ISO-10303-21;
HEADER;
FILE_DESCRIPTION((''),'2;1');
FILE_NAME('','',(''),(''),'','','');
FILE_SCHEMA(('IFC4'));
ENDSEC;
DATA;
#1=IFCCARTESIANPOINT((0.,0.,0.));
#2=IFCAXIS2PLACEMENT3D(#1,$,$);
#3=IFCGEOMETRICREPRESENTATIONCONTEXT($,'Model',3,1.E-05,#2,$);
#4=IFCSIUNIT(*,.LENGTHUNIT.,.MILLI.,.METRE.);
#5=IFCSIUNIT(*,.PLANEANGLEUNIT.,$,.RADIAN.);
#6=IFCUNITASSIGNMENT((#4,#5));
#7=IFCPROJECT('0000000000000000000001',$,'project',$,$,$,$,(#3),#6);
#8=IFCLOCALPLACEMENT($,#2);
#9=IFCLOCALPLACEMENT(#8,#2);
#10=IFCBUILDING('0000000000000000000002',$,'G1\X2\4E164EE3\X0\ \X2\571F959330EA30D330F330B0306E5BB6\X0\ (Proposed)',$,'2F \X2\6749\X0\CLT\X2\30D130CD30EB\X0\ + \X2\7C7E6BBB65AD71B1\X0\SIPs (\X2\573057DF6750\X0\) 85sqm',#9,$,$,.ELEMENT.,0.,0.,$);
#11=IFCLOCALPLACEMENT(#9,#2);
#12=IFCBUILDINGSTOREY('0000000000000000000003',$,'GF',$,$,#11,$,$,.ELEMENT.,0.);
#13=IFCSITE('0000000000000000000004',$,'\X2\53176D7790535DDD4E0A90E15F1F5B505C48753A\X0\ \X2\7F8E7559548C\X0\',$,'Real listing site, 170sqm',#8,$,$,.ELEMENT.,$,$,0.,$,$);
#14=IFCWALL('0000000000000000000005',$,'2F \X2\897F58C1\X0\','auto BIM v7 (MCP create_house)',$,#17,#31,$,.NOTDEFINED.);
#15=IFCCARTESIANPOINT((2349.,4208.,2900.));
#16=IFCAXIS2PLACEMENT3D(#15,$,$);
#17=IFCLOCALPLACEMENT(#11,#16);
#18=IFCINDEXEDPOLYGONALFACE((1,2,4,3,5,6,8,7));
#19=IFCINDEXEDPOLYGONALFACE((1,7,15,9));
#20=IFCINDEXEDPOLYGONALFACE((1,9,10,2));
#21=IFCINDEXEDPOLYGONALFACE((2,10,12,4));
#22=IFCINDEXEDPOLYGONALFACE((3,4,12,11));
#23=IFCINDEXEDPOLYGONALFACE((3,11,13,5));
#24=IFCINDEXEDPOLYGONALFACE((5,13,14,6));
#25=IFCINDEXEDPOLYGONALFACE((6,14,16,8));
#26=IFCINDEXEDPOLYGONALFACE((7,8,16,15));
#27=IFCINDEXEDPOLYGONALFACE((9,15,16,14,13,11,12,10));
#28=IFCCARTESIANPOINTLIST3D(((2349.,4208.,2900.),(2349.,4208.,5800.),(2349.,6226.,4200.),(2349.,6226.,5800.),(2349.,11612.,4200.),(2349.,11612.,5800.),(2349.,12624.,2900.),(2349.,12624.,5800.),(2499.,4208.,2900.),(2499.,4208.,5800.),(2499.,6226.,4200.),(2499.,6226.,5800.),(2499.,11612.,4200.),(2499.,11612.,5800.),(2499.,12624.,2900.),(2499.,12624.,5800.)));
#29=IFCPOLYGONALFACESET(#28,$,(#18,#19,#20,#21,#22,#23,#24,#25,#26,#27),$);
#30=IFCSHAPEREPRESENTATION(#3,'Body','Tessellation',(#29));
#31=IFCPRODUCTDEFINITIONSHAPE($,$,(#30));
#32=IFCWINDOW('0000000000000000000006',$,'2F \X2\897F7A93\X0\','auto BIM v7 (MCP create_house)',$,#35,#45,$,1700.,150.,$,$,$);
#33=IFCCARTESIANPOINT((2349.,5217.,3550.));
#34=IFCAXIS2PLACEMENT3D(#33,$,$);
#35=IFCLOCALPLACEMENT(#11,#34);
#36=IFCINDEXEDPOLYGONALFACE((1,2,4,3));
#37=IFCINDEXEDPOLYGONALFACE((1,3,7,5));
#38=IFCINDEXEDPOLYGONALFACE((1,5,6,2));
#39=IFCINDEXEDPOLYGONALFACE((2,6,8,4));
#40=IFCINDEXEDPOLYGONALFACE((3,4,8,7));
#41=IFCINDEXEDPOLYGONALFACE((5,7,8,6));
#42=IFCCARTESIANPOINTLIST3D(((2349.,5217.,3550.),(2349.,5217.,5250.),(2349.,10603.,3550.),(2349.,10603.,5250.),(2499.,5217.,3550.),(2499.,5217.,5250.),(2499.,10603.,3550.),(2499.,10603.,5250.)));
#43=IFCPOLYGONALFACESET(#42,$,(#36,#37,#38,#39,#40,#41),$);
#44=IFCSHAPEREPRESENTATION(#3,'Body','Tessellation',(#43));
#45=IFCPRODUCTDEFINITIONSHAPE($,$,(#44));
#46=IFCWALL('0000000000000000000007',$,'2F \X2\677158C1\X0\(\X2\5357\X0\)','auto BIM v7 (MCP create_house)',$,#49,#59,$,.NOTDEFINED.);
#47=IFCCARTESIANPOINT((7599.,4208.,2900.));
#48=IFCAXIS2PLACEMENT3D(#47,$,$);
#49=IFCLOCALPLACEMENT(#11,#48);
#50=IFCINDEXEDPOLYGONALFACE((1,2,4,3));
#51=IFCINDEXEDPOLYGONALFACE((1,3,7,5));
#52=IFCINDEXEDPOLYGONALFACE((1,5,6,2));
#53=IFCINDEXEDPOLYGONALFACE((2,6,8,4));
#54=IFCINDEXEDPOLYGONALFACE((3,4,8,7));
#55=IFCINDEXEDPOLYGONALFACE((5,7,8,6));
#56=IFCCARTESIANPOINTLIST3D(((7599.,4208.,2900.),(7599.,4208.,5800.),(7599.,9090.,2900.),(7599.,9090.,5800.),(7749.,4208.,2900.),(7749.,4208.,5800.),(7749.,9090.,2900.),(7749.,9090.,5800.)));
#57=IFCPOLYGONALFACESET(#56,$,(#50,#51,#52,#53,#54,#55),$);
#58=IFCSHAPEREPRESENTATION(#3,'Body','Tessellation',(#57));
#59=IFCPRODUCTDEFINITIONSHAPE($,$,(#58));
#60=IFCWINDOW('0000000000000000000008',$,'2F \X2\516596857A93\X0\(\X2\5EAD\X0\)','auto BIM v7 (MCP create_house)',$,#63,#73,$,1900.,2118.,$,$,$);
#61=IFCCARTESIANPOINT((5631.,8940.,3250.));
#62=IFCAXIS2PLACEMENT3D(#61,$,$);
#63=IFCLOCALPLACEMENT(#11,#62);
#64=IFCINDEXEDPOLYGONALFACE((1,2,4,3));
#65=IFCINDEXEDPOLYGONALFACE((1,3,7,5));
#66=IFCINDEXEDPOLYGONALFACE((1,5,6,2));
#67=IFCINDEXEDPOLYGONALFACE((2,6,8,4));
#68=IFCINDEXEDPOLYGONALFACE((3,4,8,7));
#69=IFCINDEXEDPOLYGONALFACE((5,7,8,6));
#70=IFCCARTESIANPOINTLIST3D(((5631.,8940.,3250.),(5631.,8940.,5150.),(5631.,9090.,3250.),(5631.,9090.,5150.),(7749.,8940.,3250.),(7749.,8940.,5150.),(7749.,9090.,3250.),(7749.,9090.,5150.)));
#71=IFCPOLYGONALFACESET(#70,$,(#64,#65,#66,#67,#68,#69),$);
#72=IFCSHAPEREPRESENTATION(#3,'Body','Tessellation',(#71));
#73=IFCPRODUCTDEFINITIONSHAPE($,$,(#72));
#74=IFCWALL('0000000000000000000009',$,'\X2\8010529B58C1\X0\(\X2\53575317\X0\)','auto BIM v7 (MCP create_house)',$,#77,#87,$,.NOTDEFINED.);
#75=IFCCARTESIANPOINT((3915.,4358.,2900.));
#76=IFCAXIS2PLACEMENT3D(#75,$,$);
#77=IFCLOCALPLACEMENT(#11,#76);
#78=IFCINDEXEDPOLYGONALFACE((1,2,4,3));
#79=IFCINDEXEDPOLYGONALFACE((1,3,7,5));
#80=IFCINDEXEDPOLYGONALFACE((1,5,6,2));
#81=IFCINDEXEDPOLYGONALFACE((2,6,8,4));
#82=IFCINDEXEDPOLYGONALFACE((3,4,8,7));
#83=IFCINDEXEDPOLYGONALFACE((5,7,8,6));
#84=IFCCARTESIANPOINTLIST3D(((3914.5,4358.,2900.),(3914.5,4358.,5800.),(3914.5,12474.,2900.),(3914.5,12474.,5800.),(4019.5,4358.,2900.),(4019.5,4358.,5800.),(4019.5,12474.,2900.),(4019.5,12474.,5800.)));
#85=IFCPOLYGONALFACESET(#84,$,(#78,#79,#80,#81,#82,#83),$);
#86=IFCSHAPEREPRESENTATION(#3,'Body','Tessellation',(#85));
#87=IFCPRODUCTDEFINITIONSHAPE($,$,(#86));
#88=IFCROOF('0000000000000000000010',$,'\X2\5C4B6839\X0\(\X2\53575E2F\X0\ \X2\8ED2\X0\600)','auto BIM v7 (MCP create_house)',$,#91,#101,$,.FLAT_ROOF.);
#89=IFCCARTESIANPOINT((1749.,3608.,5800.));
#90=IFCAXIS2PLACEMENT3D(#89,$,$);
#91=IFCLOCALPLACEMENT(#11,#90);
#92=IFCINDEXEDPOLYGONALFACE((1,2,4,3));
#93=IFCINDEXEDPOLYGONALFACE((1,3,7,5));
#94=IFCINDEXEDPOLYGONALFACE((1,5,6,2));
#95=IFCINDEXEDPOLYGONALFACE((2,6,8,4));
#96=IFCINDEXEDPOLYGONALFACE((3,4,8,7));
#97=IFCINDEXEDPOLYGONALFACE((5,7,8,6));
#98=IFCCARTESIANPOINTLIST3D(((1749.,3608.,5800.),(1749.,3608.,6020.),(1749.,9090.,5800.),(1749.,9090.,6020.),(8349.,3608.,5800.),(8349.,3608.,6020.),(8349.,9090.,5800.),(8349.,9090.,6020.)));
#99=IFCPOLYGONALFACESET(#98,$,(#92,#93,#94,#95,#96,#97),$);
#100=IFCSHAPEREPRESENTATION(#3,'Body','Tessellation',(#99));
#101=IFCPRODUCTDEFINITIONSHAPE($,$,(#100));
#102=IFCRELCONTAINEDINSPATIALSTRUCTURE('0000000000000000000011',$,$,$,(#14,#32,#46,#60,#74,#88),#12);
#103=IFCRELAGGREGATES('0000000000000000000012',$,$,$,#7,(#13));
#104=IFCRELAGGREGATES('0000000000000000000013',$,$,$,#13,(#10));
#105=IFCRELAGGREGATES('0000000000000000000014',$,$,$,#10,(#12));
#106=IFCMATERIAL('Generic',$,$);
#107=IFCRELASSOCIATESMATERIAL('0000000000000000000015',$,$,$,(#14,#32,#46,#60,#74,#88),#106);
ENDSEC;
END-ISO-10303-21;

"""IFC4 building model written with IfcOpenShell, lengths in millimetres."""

from ifc_helpers import new_model, si_unit, frame, frame_2d, origin, place, context, project, spatial, rectangle, extrude, material, element, fill, save


model = new_model("IFC4")

# Units and contexts
model_context = context("Model", 3, precision=1e-05, world=origin())
ifc_project = project(units=[si_unit("LENGTHUNIT", "METRE", prefix="MILLI"), si_unit("PLANEANGLEUNIT", "RADIAN")], contexts=[model_context])

# Site, building, storey
site_placement = place(None, origin())
site = spatial("IfcSite", under=ifc_project, at=site_placement, Name="北海道川上郡弟子屈町 美留和", ObjectType="Real listing site, 170sqm", CompositionType="ELEMENT", RefElevation=0.0)
building_placement = place(site_placement, origin())
building = spatial("IfcBuilding", under=site, at=building_placement, Name="G1世代 土間リビングの家 (Proposed)", ObjectType="2F 杉CLTパネル + 籾殻断熱SIPs (地域材) 85sqm", CompositionType="ELEMENT", ElevationOfRefHeight=0.0, ElevationOfTerrain=0.0)
storey_placement = place(building_placement, origin())
storey = spatial("IfcBuildingStorey", under=building, at=storey_placement, Name="GF", CompositionType="ELEMENT", Elevation=0.0)

# Shared definitions
ifc_material = material(Name="Generic")

# Walls, openings, windows
wall_1_placement = place(storey_placement, frame((2349.0, 4208.0, 2900.0)))
wall_1 = element("IfcWall", 1, at=wall_1_placement, inside=storey, material=ifc_material, Name="2F 西壁", Description="auto BIM v7 (MCP create_house)", PredefinedType="NOTDEFINED", context=model_context, shape_type="SweptSolid", body=[
    extrude(rectangle(XDim=150.0, YDim=8416.0, at=frame_2d((75.0, 4208.0))), frame((2349.0, 4208.0, 2900.0)), (0.0, 0.0, 1.0), 2900.0),
])
opening_1_placement = place(storey_placement, frame((2349.0, 5217.0, 3550.0)))
opening_1 = element("IfcOpeningElement", 2, at=opening_1_placement, cuts=wall_1, PredefinedType="NOTDEFINED", context=model_context, shape_type="SweptSolid", body=[
    extrude(rectangle(XDim=150.0, YDim=5386.0, at=frame_2d((75.0, 2693.0))), frame((2349.0, 5217.0, 3550.0)), (0.0, 0.0, 1.0), 1700.0),
])
window_1_placement = place(storey_placement, frame((2349.0, 5217.0, 3550.0)))
window_1 = element("IfcWindow", 3, at=window_1_placement, inside=storey, material=ifc_material, Name="2F 西窓", Description="auto BIM v7 (MCP create_house)", OverallHeight=1700.0, OverallWidth=150.0, context=model_context, shape_type="SweptSolid", body=[
    extrude(rectangle(XDim=150.0, YDim=5386.0, at=frame_2d((75.0, 2693.0))), frame((2349.0, 5217.0, 3550.0)), (0.0, 0.0, 1.0), 1700.0),
])
fill(opening_1, window_1)
wall_2_placement = place(storey_placement, frame((7599.0, 4208.0, 2900.0)))
wall_2 = element("IfcWall", 4, at=wall_2_placement, inside=storey, material=ifc_material, Name="2F 東壁(南)", Description="auto BIM v7 (MCP create_house)", PredefinedType="NOTDEFINED", context=model_context, shape_type="SweptSolid", body=[
    extrude(rectangle(XDim=150.0, YDim=4882.0, at=frame_2d((75.0, 2441.0))), frame((7599.0, 4208.0, 2900.0)), (0.0, 0.0, 1.0), 2900.0),
])
opening_2_placement = place(storey_placement, frame((5631.0, 8940.0, 3250.0)))
opening_2 = element("IfcOpeningElement", 5, at=opening_2_placement, cuts=wall_2, PredefinedType="NOTDEFINED", context=model_context, shape_type="SweptSolid", body=[
    extrude(rectangle(XDim=2118.0, YDim=150.0, at=frame_2d((1059.0, 75.0))), frame((5631.0, 8940.0, 3250.0)), (0.0, 0.0, 1.0), 1900.0),
])
window_2_placement = place(storey_placement, frame((5631.0, 8940.0, 3250.0)))
window_2 = element("IfcWindow", 6, at=window_2_placement, inside=storey, material=ifc_material, Name="2F 入隅窓(庭)", Description="auto BIM v7 (MCP create_house)", OverallHeight=1900.0, OverallWidth=2118.0, context=model_context, shape_type="SweptSolid", body=[
    extrude(rectangle(XDim=2118.0, YDim=150.0, at=frame_2d((1059.0, 75.0))), frame((5631.0, 8940.0, 3250.0)), (0.0, 0.0, 1.0), 1900.0),
])
fill(opening_2, window_2)

# Wall
wall_3_placement = place(storey_placement, frame((3915.0, 4358.0, 2900.0)))
element("IfcWall", 7, at=wall_3_placement, inside=storey, material=ifc_material, Name="耐力壁(南北)", Description="auto BIM v7 (MCP create_house)", PredefinedType="NOTDEFINED", context=model_context, shape_type="SweptSolid", body=[
    extrude(rectangle(XDim=105.0, YDim=8116.0, at=frame_2d((52.0, 4058.0))), frame((3915.0, 4358.0, 2900.0)), (0.0, 0.0, 1.0), 2900.0),
])

# Roof
for number, where, name in (
    (8, (1749.0, 3608.0, 5800.0), "屋根(南帯 軒600)"),
):
    element("IfcRoof", number, at=place(storey_placement, frame(where)), inside=storey, material=ifc_material, Name=name, Description="auto BIM v7 (MCP create_house)", PredefinedType="FLAT_ROOF", context=model_context, shape_type="SweptSolid", body=[
        extrude(rectangle(XDim=6600.0, YDim=5482.0, at=frame_2d((3300.0, 2741.0))), frame((1749.0, 3608.0, 5800.0)), (0.0, 0.0, 1.0), 220.0),
    ])

save(model, "model.ifc")
